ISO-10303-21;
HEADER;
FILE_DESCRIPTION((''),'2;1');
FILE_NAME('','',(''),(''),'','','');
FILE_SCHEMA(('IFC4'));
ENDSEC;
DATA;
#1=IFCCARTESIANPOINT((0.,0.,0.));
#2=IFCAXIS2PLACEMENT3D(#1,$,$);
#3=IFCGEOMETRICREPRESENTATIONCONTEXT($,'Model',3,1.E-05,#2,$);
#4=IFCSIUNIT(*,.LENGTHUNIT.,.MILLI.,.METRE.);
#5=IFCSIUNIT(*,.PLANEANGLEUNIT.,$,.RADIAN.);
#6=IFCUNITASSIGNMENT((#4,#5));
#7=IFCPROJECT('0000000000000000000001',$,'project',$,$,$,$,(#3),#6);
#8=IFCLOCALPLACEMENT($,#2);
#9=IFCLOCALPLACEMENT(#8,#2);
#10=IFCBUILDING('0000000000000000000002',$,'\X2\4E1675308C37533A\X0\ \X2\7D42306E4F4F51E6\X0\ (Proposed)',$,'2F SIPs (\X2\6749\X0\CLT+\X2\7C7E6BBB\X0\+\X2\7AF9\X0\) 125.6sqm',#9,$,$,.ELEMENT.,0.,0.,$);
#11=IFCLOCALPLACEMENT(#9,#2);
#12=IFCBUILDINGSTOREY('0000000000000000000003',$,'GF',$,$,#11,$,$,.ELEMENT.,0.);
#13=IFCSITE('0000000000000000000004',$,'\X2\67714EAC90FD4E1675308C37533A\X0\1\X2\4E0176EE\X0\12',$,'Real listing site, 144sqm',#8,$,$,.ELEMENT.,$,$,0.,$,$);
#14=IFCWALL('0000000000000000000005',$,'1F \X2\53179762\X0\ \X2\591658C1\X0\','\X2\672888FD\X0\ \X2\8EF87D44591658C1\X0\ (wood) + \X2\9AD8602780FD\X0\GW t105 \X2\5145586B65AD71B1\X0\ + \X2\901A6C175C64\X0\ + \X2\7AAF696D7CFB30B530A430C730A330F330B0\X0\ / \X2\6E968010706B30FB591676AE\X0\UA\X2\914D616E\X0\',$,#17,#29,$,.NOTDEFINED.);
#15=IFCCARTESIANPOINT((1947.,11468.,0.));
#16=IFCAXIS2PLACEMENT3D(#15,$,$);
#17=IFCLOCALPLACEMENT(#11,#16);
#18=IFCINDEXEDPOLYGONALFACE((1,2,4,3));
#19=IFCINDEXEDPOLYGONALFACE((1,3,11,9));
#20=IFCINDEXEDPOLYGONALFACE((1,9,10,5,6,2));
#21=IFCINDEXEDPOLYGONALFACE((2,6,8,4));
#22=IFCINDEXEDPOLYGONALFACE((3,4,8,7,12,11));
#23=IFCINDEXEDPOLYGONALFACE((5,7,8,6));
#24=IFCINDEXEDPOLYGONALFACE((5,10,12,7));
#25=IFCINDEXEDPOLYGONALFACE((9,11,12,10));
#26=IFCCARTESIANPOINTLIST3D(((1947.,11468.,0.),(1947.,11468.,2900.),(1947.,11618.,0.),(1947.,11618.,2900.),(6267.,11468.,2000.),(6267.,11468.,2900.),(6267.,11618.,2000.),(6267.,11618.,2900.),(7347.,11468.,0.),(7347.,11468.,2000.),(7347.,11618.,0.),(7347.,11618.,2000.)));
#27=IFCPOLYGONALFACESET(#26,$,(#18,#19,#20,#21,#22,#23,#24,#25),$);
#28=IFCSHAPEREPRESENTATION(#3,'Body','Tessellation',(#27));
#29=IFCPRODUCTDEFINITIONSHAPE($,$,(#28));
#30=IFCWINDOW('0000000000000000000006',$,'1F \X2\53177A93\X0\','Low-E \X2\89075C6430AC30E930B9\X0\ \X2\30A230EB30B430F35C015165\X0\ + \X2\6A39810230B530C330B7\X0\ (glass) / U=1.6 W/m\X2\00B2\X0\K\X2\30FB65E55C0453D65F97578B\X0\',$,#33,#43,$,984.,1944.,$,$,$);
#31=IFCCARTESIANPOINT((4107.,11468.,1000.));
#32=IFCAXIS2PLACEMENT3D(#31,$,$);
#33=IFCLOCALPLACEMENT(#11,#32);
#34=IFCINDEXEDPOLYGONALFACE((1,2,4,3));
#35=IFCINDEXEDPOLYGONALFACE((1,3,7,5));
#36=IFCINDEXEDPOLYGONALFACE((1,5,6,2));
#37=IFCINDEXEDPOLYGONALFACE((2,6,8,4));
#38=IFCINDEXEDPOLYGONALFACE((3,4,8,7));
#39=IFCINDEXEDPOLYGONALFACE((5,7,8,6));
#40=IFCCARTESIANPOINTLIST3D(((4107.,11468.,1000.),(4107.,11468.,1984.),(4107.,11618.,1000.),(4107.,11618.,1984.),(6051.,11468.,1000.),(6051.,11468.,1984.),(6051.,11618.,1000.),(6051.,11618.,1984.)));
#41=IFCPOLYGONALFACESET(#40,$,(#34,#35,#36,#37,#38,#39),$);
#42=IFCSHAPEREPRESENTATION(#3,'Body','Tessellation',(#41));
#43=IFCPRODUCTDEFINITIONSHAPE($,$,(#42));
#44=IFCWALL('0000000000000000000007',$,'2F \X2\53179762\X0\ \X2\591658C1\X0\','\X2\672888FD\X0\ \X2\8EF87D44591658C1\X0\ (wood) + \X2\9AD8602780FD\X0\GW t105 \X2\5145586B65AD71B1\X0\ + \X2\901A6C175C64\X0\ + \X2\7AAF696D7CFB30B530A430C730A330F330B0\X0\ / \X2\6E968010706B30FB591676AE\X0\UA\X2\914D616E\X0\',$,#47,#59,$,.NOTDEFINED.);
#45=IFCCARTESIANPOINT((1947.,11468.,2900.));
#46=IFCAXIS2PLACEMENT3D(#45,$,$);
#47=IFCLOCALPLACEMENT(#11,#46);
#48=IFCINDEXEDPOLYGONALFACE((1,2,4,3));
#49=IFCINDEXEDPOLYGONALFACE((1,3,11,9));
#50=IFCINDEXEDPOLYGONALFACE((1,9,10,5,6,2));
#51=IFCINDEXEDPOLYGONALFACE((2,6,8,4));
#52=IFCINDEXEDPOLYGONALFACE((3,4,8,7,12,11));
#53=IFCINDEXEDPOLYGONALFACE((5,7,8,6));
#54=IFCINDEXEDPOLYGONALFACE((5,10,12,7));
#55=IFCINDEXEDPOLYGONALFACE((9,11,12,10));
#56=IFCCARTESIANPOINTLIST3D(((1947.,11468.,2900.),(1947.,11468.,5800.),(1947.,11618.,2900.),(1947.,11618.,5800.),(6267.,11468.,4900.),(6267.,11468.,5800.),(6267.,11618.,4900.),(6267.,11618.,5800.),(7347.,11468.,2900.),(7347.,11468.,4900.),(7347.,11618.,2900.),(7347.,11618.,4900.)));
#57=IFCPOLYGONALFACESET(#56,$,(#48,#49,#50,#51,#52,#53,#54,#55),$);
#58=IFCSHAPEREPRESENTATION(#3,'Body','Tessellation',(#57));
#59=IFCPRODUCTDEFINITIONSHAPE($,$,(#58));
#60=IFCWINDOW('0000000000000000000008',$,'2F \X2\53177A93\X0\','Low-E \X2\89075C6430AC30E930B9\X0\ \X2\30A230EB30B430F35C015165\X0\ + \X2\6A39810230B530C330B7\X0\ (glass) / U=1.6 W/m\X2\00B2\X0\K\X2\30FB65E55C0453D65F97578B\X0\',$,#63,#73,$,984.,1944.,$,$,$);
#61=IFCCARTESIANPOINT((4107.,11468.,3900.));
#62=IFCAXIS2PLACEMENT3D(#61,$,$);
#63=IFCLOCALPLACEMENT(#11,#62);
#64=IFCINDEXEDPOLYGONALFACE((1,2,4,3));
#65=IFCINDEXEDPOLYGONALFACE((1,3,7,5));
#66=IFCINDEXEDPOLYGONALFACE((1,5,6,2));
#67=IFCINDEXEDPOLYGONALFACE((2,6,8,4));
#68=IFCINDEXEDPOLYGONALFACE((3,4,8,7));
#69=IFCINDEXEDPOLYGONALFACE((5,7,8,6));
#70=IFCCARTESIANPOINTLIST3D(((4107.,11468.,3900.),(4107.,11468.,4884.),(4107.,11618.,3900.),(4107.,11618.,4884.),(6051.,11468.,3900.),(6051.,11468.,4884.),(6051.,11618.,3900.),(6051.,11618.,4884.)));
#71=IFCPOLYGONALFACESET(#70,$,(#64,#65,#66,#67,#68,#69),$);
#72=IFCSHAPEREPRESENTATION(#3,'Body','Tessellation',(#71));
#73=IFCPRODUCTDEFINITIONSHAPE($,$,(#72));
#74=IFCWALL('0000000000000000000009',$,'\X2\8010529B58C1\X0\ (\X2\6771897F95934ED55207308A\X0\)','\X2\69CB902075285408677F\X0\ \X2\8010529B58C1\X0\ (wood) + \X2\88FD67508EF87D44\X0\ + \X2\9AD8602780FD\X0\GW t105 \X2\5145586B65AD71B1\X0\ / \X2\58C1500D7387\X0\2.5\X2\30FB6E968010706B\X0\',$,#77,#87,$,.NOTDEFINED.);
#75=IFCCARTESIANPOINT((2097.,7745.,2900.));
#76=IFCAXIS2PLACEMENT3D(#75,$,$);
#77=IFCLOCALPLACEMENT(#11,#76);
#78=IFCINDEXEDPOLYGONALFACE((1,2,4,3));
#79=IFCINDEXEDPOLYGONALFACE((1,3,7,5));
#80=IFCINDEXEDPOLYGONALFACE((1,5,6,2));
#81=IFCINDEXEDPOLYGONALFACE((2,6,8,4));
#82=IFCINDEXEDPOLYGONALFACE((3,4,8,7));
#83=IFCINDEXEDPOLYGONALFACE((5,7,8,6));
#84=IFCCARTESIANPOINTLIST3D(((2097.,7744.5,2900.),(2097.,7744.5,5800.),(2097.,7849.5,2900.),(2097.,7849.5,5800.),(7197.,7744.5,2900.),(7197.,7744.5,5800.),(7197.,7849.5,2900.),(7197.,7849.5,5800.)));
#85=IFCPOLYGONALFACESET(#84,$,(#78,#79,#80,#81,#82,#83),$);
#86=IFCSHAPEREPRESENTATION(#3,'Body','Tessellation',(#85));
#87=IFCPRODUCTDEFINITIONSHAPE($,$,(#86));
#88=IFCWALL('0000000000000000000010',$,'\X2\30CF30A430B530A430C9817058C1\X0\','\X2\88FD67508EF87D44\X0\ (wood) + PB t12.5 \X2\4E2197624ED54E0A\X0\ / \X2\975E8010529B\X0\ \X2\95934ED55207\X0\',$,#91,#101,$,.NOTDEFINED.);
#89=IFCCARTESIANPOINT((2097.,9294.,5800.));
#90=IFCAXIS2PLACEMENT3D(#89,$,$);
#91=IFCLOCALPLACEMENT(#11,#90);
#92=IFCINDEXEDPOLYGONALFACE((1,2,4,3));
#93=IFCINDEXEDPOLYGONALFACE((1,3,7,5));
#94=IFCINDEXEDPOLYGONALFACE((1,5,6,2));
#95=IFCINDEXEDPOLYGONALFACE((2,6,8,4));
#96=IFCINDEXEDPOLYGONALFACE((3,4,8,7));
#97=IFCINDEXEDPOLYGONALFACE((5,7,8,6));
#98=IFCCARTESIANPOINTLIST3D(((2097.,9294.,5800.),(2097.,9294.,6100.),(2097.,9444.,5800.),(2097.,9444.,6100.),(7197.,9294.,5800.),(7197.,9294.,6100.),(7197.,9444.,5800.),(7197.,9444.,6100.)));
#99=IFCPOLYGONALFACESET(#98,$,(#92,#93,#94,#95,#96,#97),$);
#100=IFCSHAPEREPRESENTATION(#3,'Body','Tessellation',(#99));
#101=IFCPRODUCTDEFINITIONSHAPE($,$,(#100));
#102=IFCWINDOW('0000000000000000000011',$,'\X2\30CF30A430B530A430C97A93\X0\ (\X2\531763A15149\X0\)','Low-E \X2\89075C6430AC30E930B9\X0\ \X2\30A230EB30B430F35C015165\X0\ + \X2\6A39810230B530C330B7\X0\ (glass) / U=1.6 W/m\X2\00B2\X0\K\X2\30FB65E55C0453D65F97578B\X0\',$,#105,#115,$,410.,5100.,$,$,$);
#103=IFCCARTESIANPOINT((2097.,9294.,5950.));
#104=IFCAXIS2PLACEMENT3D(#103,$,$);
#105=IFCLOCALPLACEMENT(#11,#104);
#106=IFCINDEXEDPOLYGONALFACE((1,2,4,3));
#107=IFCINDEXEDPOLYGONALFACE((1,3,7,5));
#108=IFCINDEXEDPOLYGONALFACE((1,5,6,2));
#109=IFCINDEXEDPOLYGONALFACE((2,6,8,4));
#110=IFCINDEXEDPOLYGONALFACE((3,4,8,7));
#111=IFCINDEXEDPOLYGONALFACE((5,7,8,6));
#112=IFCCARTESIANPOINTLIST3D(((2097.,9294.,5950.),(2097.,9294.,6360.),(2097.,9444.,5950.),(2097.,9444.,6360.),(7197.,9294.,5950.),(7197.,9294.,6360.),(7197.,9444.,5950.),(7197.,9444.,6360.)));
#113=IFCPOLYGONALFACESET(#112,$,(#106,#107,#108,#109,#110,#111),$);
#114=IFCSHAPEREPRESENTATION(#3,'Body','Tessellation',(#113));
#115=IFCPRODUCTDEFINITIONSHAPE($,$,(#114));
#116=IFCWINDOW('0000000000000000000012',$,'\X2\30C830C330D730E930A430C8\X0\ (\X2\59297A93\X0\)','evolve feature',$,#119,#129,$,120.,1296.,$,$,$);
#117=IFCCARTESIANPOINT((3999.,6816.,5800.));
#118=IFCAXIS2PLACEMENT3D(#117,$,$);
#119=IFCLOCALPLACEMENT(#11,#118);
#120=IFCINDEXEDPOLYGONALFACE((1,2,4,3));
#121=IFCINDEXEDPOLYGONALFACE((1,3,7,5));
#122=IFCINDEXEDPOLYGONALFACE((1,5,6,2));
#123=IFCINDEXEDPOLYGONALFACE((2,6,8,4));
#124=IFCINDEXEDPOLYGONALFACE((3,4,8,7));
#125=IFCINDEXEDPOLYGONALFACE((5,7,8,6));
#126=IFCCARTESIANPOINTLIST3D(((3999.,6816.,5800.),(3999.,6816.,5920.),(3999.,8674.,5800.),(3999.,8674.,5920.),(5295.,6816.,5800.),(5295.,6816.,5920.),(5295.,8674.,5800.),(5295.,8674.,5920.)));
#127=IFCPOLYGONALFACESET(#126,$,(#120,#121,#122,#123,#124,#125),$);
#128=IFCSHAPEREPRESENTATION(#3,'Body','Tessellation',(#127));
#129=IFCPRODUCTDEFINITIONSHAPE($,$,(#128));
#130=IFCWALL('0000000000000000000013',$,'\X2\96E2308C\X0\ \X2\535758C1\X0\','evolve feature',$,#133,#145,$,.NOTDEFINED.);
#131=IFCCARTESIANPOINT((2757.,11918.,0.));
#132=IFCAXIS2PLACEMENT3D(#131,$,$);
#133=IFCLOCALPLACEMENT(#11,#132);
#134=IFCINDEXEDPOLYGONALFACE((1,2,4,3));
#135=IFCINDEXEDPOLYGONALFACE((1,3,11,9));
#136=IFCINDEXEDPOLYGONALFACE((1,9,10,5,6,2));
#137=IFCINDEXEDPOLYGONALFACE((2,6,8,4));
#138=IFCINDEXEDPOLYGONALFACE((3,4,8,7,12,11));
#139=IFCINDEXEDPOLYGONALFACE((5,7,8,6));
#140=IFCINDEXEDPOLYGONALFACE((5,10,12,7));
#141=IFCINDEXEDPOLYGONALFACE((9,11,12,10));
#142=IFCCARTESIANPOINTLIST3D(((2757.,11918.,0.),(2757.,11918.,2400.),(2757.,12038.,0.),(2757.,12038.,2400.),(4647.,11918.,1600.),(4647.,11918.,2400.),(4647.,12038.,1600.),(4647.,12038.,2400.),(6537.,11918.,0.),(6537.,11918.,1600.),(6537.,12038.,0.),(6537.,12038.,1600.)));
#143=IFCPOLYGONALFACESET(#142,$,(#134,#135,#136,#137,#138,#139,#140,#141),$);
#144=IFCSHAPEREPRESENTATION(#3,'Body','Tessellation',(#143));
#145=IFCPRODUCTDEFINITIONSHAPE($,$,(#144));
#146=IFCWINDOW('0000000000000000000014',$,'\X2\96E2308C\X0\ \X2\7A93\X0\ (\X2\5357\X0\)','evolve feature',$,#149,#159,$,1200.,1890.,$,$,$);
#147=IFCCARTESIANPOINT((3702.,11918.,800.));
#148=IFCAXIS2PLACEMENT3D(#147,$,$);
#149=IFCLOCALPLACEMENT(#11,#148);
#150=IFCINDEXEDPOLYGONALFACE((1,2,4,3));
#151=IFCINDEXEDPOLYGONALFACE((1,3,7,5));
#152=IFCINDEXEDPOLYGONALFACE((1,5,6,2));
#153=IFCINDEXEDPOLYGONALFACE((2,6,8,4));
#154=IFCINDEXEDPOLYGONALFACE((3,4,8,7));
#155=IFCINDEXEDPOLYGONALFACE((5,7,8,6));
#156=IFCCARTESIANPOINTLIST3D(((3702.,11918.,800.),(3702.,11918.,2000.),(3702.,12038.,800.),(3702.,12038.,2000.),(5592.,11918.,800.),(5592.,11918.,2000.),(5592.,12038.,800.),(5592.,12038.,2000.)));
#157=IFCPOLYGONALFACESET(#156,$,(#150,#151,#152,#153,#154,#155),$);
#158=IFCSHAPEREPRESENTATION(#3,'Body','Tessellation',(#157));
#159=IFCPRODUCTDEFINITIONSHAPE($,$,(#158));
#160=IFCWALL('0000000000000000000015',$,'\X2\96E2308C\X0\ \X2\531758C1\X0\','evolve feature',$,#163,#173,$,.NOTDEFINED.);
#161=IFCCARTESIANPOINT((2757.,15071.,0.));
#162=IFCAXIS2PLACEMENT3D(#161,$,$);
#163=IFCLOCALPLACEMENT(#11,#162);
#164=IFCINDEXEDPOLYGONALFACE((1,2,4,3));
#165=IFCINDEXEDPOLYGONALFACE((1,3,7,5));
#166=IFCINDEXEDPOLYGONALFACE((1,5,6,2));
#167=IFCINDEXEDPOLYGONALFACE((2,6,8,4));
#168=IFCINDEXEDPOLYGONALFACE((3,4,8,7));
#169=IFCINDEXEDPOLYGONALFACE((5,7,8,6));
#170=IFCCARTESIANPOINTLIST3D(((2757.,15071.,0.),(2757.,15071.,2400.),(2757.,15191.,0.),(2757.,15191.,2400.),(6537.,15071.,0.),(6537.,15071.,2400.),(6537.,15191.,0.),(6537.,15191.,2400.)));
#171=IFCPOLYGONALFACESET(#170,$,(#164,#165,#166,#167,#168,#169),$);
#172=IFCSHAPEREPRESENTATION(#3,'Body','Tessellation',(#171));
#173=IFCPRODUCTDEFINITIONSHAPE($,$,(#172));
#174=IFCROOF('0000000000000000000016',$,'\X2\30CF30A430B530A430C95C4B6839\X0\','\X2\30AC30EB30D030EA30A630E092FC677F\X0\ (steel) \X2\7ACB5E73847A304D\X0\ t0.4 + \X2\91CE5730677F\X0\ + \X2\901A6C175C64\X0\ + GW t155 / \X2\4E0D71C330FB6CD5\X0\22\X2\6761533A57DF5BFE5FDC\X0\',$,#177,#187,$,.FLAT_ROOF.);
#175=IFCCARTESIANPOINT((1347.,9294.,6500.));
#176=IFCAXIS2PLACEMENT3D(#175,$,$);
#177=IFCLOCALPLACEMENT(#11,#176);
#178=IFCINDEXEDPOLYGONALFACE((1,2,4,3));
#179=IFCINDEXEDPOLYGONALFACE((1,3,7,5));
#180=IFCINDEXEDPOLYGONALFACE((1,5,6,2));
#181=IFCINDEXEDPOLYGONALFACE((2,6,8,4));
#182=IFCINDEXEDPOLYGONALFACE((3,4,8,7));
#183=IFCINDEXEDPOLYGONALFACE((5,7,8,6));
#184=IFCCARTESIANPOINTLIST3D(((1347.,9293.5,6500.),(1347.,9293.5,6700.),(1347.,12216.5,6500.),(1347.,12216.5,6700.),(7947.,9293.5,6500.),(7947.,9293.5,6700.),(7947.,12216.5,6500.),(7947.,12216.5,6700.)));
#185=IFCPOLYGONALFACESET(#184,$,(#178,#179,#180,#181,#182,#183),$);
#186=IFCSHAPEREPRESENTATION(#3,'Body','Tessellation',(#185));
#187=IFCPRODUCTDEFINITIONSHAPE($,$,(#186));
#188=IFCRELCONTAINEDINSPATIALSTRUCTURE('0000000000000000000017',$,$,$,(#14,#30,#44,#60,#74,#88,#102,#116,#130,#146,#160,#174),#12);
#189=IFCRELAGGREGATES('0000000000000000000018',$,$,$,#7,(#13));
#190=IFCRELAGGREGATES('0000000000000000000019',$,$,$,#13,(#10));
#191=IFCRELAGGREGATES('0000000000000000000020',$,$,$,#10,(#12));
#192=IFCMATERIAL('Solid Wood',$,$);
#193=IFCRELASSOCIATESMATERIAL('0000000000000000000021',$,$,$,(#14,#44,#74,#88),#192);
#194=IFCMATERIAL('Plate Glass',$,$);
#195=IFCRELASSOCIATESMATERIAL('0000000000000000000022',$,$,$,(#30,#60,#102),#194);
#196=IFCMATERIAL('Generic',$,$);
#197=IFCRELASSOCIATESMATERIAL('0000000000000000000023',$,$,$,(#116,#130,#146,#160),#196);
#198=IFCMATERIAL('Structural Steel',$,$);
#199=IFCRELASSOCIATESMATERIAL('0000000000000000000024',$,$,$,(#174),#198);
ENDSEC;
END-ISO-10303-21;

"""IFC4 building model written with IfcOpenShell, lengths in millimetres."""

from ifc_helpers import new_model, si_unit, frame, frame_2d, origin, place, context, project, spatial, rectangle, extrude, material, element, fill, save


model = new_model("IFC4")

# Units and contexts
model_context = context("Model", 3, precision=1e-05, world=origin())
ifc_project = project(units=[si_unit("LENGTHUNIT", "METRE", prefix="MILLI"), si_unit("PLANEANGLEUNIT", "RADIAN")], contexts=[model_context])

# Site, building, storey
site_placement = place(None, origin())
site = spatial("IfcSite", under=ifc_project, at=site_placement, Name="東京都世田谷区1丁目12", ObjectType="Real listing site, 144sqm", CompositionType="ELEMENT", RefElevation=0.0)
building_placement = place(site_placement, origin())
building = spatial("IfcBuilding", under=site, at=building_placement, Name="世田谷区 終の住処 (Proposed)", ObjectType="2F SIPs (杉CLT+籾殻+竹) 125.6sqm", CompositionType="ELEMENT", ElevationOfRefHeight=0.0, ElevationOfTerrain=0.0)
storey_placement = place(building_placement, origin())
storey = spatial("IfcBuildingStorey", under=building, at=storey_placement, Name="GF", CompositionType="ELEMENT", Elevation=0.0)

# Shared definitions
ifc_material_1 = material(Name="Generic")

# Wall, opening, window
ifc_material_2 = material(Name="Solid Wood")
wall_1_placement = place(storey_placement, frame((1947.0, 11468.0, 0.0)))
wall_1 = element("IfcWall", 1, at=wall_1_placement, inside=storey, material=ifc_material_2, Name="1F 北面 外壁", Description="木製 軸組外壁 (wood) + 高性能GW t105 充填断熱 + 通気層 + 窯業系サイディング / 準耐火・外皮UA配慮", PredefinedType="NOTDEFINED", context=model_context, shape_type="SweptSolid", body=[
    extrude(rectangle(XDim=5400.0, YDim=150.0, at=frame_2d((2700.0, 75.0))), frame((1947.0, 11468.0, 0.0)), (0.0, 0.0, 1.0), 2900.0),
])
opening_1_placement = place(storey_placement, frame((4107.0, 11468.0, 1000.0)))
opening_1 = element("IfcOpeningElement", 2, at=opening_1_placement, cuts=wall_1, PredefinedType="NOTDEFINED", context=model_context, shape_type="SweptSolid", body=[
    extrude(rectangle(XDim=1944.0, YDim=150.0, at=frame_2d((972.0, 75.0))), frame((4107.0, 11468.0, 1000.0)), (0.0, 0.0, 1.0), 984.0),
])
ifc_material_3 = material(Name="Plate Glass")
window_1_placement = place(storey_placement, frame((4107.0, 11468.0, 1000.0)))
window_1 = element("IfcWindow", 3, at=window_1_placement, inside=storey, material=ifc_material_3, Name="1F 北窓", Description="Low-E 複層ガラス アルゴン封入 + 樹脂サッシ (glass) / U=1.6 W/m²K・日射取得型", OverallHeight=984.0, OverallWidth=1944.0, context=model_context, shape_type="SweptSolid", body=[
    extrude(rectangle(XDim=1944.0, YDim=150.0, at=frame_2d((972.0, 75.0))), frame((4107.0, 11468.0, 1000.0)), (0.0, 0.0, 1.0), 984.0),
])
fill(opening_1, window_1)

# Wall, opening, window
wall_2_placement = place(storey_placement, frame((1947.0, 11468.0, 2900.0)))
wall_2 = element("IfcWall", 4, at=wall_2_placement, inside=storey, material=ifc_material_2, Name="2F 北面 外壁", Description="木製 軸組外壁 (wood) + 高性能GW t105 充填断熱 + 通気層 + 窯業系サイディング / 準耐火・外皮UA配慮", PredefinedType="NOTDEFINED", context=model_context, shape_type="SweptSolid", body=[
    extrude(rectangle(XDim=5400.0, YDim=150.0, at=frame_2d((2700.0, 75.0))), frame((1947.0, 11468.0, 2900.0)), (0.0, 0.0, 1.0), 2900.0),
])
opening_2_placement = place(storey_placement, frame((4107.0, 11468.0, 3900.0)))
opening_2 = element("IfcOpeningElement", 5, at=opening_2_placement, cuts=wall_2, PredefinedType="NOTDEFINED", context=model_context, shape_type="SweptSolid", body=[
    extrude(rectangle(XDim=1944.0, YDim=150.0, at=frame_2d((972.0, 75.0))), frame((4107.0, 11468.0, 3900.0)), (0.0, 0.0, 1.0), 984.0),
])
window_2_placement = place(storey_placement, frame((4107.0, 11468.0, 3900.0)))
window_2 = element("IfcWindow", 6, at=window_2_placement, inside=storey, material=ifc_material_3, Name="2F 北窓", Description="Low-E 複層ガラス アルゴン封入 + 樹脂サッシ (glass) / U=1.6 W/m²K・日射取得型", OverallHeight=984.0, OverallWidth=1944.0, context=model_context, shape_type="SweptSolid", body=[
    extrude(rectangle(XDim=1944.0, YDim=150.0, at=frame_2d((972.0, 75.0))), frame((4107.0, 11468.0, 3900.0)), (0.0, 0.0, 1.0), 984.0),
])
fill(opening_2, window_2)

# Wall
wall_3_placement = place(storey_placement, frame((2097.0, 7745.0, 2900.0)))
element("IfcWall", 7, at=wall_3_placement, inside=storey, material=ifc_material_2, Name="耐力壁 (東西間仕切り)", Description="構造用合板 耐力壁 (wood) + 製材軸組 + 高性能GW t105 充填断熱 / 壁倍率2.5・準耐火", PredefinedType="NOTDEFINED", context=model_context, shape_type="SweptSolid", body=[
    extrude(rectangle(XDim=5100.0, YDim=105.0, at=frame_2d((2550.0, 52.0))), frame((2097.0, 7745.0, 2900.0)), (0.0, 0.0, 1.0), 2900.0),
])

# Wall, opening, window
wall_4_placement = place(storey_placement, frame((2097.0, 9294.0, 5800.0)))
wall_4 = element("IfcWall", 8, at=wall_4_placement, inside=storey, material=ifc_material_2, Name="ハイサイド腰壁", Description="製材軸組 (wood) + PB t12.5 両面仕上 / 非耐力 間仕切", PredefinedType="NOTDEFINED", context=model_context, shape_type="SweptSolid", body=[
    extrude(rectangle(XDim=5100.0, YDim=150.0, at=frame_2d((2550.0, 75.0))), frame((2097.0, 9294.0, 5800.0)), (0.0, 0.0, 1.0), 700.0),
])
opening_3_placement = place(storey_placement, frame((2097.0, 9294.0, 5950.0)))
opening_3 = element("IfcOpeningElement", 9, at=opening_3_placement, cuts=wall_4, PredefinedType="NOTDEFINED", context=model_context, shape_type="SweptSolid", body=[
    extrude(rectangle(XDim=5100.0, YDim=150.0, at=frame_2d((2550.0, 75.0))), frame((2097.0, 9294.0, 5950.0)), (0.0, 0.0, 1.0), 410.0),
])
window_3_placement = place(storey_placement, frame((2097.0, 9294.0, 5950.0)))
window_3 = element("IfcWindow", 10, at=window_3_placement, inside=storey, material=ifc_material_3, Name="ハイサイド窓 (北採光)", Description="Low-E 複層ガラス アルゴン封入 + 樹脂サッシ (glass) / U=1.6 W/m²K・日射取得型", OverallHeight=410.0, OverallWidth=5100.0, context=model_context, shape_type="SweptSolid", body=[
    extrude(rectangle(XDim=5100.0, YDim=150.0, at=frame_2d((2550.0, 75.0))), frame((2097.0, 9294.0, 5950.0)), (0.0, 0.0, 1.0), 410.0),
])
fill(opening_3, window_3)

# Window
window_4_placement = place(storey_placement, frame((3999.0, 6816.0, 5800.0)))
element("IfcWindow", 11, at=window_4_placement, inside=storey, material=ifc_material_1, Name="トップライト (天窓)", Description="evolve feature", OverallHeight=120.0, OverallWidth=1296.0, context=model_context, shape_type="SweptSolid", body=[
    extrude(rectangle(XDim=1296.0, YDim=1858.0, at=frame_2d((648.0, 929.0))), frame((3999.0, 6816.0, 5800.0)), (0.0, 0.0, 1.0), 120.0),
])

# Wall, opening, window
wall_5_placement = place(storey_placement, frame((2757.0, 11918.0, 0.0)))
wall_5 = element("IfcWall", 12, at=wall_5_placement, inside=storey, material=ifc_material_1, Name="離れ 南壁", Description="evolve feature", PredefinedType="NOTDEFINED", context=model_context, shape_type="SweptSolid", body=[
    extrude(rectangle(XDim=3780.0, YDim=120.0, at=frame_2d((1890.0, 60.0))), frame((2757.0, 11918.0, 0.0)), (0.0, 0.0, 1.0), 2400.0),
])
opening_4_placement = place(storey_placement, frame((3702.0, 11918.0, 800.0)))
opening_4 = element("IfcOpeningElement", 13, at=opening_4_placement, cuts=wall_5, PredefinedType="NOTDEFINED", context=model_context, shape_type="SweptSolid", body=[
    extrude(rectangle(XDim=1890.0, YDim=120.0, at=frame_2d((945.0, 60.0))), frame((3702.0, 11918.0, 800.0)), (0.0, 0.0, 1.0), 1200.0),
])
window_5_placement = place(storey_placement, frame((3702.0, 11918.0, 800.0)))
window_5 = element("IfcWindow", 14, at=window_5_placement, inside=storey, material=ifc_material_1, Name="離れ 窓 (南)", Description="evolve feature", OverallHeight=1200.0, OverallWidth=1890.0, context=model_context, shape_type="SweptSolid", body=[
    extrude(rectangle(XDim=1890.0, YDim=120.0, at=frame_2d((945.0, 60.0))), frame((3702.0, 11918.0, 800.0)), (0.0, 0.0, 1.0), 1200.0),
])
fill(opening_4, window_5)

# Wall
wall_6_placement = place(storey_placement, frame((2757.0, 15071.0, 0.0)))
element("IfcWall", 15, at=wall_6_placement, inside=storey, material=ifc_material_1, Name="離れ 北壁", Description="evolve feature", PredefinedType="NOTDEFINED", context=model_context, shape_type="SweptSolid", body=[
    extrude(rectangle(XDim=3780.0, YDim=120.0, at=frame_2d((1890.0, 60.0))), frame((2757.0, 15071.0, 0.0)), (0.0, 0.0, 1.0), 2400.0),
])

# Roof
ifc_material_4 = material(Name="Structural Steel")
roof_1_placement = place(storey_placement, frame((1347.0, 9294.0, 6500.0)))
element("IfcRoof", 16, at=roof_1_placement, inside=storey, material=ifc_material_4, Name="ハイサイド屋根", Description="ガルバリウム鋼板 (steel) 立平葺き t0.4 + 野地板 + 通気層 + GW t155 / 不燃・法22条区域対応", PredefinedType="FLAT_ROOF", context=model_context, shape_type="SweptSolid", body=[
    extrude(rectangle(XDim=6600.0, YDim=2923.0, at=frame_2d((3300.0, 1461.0))), frame((1347.0, 9294.0, 6500.0)), (0.0, 0.0, 1.0), 200.0),
])

save(model, "model.ifc")
